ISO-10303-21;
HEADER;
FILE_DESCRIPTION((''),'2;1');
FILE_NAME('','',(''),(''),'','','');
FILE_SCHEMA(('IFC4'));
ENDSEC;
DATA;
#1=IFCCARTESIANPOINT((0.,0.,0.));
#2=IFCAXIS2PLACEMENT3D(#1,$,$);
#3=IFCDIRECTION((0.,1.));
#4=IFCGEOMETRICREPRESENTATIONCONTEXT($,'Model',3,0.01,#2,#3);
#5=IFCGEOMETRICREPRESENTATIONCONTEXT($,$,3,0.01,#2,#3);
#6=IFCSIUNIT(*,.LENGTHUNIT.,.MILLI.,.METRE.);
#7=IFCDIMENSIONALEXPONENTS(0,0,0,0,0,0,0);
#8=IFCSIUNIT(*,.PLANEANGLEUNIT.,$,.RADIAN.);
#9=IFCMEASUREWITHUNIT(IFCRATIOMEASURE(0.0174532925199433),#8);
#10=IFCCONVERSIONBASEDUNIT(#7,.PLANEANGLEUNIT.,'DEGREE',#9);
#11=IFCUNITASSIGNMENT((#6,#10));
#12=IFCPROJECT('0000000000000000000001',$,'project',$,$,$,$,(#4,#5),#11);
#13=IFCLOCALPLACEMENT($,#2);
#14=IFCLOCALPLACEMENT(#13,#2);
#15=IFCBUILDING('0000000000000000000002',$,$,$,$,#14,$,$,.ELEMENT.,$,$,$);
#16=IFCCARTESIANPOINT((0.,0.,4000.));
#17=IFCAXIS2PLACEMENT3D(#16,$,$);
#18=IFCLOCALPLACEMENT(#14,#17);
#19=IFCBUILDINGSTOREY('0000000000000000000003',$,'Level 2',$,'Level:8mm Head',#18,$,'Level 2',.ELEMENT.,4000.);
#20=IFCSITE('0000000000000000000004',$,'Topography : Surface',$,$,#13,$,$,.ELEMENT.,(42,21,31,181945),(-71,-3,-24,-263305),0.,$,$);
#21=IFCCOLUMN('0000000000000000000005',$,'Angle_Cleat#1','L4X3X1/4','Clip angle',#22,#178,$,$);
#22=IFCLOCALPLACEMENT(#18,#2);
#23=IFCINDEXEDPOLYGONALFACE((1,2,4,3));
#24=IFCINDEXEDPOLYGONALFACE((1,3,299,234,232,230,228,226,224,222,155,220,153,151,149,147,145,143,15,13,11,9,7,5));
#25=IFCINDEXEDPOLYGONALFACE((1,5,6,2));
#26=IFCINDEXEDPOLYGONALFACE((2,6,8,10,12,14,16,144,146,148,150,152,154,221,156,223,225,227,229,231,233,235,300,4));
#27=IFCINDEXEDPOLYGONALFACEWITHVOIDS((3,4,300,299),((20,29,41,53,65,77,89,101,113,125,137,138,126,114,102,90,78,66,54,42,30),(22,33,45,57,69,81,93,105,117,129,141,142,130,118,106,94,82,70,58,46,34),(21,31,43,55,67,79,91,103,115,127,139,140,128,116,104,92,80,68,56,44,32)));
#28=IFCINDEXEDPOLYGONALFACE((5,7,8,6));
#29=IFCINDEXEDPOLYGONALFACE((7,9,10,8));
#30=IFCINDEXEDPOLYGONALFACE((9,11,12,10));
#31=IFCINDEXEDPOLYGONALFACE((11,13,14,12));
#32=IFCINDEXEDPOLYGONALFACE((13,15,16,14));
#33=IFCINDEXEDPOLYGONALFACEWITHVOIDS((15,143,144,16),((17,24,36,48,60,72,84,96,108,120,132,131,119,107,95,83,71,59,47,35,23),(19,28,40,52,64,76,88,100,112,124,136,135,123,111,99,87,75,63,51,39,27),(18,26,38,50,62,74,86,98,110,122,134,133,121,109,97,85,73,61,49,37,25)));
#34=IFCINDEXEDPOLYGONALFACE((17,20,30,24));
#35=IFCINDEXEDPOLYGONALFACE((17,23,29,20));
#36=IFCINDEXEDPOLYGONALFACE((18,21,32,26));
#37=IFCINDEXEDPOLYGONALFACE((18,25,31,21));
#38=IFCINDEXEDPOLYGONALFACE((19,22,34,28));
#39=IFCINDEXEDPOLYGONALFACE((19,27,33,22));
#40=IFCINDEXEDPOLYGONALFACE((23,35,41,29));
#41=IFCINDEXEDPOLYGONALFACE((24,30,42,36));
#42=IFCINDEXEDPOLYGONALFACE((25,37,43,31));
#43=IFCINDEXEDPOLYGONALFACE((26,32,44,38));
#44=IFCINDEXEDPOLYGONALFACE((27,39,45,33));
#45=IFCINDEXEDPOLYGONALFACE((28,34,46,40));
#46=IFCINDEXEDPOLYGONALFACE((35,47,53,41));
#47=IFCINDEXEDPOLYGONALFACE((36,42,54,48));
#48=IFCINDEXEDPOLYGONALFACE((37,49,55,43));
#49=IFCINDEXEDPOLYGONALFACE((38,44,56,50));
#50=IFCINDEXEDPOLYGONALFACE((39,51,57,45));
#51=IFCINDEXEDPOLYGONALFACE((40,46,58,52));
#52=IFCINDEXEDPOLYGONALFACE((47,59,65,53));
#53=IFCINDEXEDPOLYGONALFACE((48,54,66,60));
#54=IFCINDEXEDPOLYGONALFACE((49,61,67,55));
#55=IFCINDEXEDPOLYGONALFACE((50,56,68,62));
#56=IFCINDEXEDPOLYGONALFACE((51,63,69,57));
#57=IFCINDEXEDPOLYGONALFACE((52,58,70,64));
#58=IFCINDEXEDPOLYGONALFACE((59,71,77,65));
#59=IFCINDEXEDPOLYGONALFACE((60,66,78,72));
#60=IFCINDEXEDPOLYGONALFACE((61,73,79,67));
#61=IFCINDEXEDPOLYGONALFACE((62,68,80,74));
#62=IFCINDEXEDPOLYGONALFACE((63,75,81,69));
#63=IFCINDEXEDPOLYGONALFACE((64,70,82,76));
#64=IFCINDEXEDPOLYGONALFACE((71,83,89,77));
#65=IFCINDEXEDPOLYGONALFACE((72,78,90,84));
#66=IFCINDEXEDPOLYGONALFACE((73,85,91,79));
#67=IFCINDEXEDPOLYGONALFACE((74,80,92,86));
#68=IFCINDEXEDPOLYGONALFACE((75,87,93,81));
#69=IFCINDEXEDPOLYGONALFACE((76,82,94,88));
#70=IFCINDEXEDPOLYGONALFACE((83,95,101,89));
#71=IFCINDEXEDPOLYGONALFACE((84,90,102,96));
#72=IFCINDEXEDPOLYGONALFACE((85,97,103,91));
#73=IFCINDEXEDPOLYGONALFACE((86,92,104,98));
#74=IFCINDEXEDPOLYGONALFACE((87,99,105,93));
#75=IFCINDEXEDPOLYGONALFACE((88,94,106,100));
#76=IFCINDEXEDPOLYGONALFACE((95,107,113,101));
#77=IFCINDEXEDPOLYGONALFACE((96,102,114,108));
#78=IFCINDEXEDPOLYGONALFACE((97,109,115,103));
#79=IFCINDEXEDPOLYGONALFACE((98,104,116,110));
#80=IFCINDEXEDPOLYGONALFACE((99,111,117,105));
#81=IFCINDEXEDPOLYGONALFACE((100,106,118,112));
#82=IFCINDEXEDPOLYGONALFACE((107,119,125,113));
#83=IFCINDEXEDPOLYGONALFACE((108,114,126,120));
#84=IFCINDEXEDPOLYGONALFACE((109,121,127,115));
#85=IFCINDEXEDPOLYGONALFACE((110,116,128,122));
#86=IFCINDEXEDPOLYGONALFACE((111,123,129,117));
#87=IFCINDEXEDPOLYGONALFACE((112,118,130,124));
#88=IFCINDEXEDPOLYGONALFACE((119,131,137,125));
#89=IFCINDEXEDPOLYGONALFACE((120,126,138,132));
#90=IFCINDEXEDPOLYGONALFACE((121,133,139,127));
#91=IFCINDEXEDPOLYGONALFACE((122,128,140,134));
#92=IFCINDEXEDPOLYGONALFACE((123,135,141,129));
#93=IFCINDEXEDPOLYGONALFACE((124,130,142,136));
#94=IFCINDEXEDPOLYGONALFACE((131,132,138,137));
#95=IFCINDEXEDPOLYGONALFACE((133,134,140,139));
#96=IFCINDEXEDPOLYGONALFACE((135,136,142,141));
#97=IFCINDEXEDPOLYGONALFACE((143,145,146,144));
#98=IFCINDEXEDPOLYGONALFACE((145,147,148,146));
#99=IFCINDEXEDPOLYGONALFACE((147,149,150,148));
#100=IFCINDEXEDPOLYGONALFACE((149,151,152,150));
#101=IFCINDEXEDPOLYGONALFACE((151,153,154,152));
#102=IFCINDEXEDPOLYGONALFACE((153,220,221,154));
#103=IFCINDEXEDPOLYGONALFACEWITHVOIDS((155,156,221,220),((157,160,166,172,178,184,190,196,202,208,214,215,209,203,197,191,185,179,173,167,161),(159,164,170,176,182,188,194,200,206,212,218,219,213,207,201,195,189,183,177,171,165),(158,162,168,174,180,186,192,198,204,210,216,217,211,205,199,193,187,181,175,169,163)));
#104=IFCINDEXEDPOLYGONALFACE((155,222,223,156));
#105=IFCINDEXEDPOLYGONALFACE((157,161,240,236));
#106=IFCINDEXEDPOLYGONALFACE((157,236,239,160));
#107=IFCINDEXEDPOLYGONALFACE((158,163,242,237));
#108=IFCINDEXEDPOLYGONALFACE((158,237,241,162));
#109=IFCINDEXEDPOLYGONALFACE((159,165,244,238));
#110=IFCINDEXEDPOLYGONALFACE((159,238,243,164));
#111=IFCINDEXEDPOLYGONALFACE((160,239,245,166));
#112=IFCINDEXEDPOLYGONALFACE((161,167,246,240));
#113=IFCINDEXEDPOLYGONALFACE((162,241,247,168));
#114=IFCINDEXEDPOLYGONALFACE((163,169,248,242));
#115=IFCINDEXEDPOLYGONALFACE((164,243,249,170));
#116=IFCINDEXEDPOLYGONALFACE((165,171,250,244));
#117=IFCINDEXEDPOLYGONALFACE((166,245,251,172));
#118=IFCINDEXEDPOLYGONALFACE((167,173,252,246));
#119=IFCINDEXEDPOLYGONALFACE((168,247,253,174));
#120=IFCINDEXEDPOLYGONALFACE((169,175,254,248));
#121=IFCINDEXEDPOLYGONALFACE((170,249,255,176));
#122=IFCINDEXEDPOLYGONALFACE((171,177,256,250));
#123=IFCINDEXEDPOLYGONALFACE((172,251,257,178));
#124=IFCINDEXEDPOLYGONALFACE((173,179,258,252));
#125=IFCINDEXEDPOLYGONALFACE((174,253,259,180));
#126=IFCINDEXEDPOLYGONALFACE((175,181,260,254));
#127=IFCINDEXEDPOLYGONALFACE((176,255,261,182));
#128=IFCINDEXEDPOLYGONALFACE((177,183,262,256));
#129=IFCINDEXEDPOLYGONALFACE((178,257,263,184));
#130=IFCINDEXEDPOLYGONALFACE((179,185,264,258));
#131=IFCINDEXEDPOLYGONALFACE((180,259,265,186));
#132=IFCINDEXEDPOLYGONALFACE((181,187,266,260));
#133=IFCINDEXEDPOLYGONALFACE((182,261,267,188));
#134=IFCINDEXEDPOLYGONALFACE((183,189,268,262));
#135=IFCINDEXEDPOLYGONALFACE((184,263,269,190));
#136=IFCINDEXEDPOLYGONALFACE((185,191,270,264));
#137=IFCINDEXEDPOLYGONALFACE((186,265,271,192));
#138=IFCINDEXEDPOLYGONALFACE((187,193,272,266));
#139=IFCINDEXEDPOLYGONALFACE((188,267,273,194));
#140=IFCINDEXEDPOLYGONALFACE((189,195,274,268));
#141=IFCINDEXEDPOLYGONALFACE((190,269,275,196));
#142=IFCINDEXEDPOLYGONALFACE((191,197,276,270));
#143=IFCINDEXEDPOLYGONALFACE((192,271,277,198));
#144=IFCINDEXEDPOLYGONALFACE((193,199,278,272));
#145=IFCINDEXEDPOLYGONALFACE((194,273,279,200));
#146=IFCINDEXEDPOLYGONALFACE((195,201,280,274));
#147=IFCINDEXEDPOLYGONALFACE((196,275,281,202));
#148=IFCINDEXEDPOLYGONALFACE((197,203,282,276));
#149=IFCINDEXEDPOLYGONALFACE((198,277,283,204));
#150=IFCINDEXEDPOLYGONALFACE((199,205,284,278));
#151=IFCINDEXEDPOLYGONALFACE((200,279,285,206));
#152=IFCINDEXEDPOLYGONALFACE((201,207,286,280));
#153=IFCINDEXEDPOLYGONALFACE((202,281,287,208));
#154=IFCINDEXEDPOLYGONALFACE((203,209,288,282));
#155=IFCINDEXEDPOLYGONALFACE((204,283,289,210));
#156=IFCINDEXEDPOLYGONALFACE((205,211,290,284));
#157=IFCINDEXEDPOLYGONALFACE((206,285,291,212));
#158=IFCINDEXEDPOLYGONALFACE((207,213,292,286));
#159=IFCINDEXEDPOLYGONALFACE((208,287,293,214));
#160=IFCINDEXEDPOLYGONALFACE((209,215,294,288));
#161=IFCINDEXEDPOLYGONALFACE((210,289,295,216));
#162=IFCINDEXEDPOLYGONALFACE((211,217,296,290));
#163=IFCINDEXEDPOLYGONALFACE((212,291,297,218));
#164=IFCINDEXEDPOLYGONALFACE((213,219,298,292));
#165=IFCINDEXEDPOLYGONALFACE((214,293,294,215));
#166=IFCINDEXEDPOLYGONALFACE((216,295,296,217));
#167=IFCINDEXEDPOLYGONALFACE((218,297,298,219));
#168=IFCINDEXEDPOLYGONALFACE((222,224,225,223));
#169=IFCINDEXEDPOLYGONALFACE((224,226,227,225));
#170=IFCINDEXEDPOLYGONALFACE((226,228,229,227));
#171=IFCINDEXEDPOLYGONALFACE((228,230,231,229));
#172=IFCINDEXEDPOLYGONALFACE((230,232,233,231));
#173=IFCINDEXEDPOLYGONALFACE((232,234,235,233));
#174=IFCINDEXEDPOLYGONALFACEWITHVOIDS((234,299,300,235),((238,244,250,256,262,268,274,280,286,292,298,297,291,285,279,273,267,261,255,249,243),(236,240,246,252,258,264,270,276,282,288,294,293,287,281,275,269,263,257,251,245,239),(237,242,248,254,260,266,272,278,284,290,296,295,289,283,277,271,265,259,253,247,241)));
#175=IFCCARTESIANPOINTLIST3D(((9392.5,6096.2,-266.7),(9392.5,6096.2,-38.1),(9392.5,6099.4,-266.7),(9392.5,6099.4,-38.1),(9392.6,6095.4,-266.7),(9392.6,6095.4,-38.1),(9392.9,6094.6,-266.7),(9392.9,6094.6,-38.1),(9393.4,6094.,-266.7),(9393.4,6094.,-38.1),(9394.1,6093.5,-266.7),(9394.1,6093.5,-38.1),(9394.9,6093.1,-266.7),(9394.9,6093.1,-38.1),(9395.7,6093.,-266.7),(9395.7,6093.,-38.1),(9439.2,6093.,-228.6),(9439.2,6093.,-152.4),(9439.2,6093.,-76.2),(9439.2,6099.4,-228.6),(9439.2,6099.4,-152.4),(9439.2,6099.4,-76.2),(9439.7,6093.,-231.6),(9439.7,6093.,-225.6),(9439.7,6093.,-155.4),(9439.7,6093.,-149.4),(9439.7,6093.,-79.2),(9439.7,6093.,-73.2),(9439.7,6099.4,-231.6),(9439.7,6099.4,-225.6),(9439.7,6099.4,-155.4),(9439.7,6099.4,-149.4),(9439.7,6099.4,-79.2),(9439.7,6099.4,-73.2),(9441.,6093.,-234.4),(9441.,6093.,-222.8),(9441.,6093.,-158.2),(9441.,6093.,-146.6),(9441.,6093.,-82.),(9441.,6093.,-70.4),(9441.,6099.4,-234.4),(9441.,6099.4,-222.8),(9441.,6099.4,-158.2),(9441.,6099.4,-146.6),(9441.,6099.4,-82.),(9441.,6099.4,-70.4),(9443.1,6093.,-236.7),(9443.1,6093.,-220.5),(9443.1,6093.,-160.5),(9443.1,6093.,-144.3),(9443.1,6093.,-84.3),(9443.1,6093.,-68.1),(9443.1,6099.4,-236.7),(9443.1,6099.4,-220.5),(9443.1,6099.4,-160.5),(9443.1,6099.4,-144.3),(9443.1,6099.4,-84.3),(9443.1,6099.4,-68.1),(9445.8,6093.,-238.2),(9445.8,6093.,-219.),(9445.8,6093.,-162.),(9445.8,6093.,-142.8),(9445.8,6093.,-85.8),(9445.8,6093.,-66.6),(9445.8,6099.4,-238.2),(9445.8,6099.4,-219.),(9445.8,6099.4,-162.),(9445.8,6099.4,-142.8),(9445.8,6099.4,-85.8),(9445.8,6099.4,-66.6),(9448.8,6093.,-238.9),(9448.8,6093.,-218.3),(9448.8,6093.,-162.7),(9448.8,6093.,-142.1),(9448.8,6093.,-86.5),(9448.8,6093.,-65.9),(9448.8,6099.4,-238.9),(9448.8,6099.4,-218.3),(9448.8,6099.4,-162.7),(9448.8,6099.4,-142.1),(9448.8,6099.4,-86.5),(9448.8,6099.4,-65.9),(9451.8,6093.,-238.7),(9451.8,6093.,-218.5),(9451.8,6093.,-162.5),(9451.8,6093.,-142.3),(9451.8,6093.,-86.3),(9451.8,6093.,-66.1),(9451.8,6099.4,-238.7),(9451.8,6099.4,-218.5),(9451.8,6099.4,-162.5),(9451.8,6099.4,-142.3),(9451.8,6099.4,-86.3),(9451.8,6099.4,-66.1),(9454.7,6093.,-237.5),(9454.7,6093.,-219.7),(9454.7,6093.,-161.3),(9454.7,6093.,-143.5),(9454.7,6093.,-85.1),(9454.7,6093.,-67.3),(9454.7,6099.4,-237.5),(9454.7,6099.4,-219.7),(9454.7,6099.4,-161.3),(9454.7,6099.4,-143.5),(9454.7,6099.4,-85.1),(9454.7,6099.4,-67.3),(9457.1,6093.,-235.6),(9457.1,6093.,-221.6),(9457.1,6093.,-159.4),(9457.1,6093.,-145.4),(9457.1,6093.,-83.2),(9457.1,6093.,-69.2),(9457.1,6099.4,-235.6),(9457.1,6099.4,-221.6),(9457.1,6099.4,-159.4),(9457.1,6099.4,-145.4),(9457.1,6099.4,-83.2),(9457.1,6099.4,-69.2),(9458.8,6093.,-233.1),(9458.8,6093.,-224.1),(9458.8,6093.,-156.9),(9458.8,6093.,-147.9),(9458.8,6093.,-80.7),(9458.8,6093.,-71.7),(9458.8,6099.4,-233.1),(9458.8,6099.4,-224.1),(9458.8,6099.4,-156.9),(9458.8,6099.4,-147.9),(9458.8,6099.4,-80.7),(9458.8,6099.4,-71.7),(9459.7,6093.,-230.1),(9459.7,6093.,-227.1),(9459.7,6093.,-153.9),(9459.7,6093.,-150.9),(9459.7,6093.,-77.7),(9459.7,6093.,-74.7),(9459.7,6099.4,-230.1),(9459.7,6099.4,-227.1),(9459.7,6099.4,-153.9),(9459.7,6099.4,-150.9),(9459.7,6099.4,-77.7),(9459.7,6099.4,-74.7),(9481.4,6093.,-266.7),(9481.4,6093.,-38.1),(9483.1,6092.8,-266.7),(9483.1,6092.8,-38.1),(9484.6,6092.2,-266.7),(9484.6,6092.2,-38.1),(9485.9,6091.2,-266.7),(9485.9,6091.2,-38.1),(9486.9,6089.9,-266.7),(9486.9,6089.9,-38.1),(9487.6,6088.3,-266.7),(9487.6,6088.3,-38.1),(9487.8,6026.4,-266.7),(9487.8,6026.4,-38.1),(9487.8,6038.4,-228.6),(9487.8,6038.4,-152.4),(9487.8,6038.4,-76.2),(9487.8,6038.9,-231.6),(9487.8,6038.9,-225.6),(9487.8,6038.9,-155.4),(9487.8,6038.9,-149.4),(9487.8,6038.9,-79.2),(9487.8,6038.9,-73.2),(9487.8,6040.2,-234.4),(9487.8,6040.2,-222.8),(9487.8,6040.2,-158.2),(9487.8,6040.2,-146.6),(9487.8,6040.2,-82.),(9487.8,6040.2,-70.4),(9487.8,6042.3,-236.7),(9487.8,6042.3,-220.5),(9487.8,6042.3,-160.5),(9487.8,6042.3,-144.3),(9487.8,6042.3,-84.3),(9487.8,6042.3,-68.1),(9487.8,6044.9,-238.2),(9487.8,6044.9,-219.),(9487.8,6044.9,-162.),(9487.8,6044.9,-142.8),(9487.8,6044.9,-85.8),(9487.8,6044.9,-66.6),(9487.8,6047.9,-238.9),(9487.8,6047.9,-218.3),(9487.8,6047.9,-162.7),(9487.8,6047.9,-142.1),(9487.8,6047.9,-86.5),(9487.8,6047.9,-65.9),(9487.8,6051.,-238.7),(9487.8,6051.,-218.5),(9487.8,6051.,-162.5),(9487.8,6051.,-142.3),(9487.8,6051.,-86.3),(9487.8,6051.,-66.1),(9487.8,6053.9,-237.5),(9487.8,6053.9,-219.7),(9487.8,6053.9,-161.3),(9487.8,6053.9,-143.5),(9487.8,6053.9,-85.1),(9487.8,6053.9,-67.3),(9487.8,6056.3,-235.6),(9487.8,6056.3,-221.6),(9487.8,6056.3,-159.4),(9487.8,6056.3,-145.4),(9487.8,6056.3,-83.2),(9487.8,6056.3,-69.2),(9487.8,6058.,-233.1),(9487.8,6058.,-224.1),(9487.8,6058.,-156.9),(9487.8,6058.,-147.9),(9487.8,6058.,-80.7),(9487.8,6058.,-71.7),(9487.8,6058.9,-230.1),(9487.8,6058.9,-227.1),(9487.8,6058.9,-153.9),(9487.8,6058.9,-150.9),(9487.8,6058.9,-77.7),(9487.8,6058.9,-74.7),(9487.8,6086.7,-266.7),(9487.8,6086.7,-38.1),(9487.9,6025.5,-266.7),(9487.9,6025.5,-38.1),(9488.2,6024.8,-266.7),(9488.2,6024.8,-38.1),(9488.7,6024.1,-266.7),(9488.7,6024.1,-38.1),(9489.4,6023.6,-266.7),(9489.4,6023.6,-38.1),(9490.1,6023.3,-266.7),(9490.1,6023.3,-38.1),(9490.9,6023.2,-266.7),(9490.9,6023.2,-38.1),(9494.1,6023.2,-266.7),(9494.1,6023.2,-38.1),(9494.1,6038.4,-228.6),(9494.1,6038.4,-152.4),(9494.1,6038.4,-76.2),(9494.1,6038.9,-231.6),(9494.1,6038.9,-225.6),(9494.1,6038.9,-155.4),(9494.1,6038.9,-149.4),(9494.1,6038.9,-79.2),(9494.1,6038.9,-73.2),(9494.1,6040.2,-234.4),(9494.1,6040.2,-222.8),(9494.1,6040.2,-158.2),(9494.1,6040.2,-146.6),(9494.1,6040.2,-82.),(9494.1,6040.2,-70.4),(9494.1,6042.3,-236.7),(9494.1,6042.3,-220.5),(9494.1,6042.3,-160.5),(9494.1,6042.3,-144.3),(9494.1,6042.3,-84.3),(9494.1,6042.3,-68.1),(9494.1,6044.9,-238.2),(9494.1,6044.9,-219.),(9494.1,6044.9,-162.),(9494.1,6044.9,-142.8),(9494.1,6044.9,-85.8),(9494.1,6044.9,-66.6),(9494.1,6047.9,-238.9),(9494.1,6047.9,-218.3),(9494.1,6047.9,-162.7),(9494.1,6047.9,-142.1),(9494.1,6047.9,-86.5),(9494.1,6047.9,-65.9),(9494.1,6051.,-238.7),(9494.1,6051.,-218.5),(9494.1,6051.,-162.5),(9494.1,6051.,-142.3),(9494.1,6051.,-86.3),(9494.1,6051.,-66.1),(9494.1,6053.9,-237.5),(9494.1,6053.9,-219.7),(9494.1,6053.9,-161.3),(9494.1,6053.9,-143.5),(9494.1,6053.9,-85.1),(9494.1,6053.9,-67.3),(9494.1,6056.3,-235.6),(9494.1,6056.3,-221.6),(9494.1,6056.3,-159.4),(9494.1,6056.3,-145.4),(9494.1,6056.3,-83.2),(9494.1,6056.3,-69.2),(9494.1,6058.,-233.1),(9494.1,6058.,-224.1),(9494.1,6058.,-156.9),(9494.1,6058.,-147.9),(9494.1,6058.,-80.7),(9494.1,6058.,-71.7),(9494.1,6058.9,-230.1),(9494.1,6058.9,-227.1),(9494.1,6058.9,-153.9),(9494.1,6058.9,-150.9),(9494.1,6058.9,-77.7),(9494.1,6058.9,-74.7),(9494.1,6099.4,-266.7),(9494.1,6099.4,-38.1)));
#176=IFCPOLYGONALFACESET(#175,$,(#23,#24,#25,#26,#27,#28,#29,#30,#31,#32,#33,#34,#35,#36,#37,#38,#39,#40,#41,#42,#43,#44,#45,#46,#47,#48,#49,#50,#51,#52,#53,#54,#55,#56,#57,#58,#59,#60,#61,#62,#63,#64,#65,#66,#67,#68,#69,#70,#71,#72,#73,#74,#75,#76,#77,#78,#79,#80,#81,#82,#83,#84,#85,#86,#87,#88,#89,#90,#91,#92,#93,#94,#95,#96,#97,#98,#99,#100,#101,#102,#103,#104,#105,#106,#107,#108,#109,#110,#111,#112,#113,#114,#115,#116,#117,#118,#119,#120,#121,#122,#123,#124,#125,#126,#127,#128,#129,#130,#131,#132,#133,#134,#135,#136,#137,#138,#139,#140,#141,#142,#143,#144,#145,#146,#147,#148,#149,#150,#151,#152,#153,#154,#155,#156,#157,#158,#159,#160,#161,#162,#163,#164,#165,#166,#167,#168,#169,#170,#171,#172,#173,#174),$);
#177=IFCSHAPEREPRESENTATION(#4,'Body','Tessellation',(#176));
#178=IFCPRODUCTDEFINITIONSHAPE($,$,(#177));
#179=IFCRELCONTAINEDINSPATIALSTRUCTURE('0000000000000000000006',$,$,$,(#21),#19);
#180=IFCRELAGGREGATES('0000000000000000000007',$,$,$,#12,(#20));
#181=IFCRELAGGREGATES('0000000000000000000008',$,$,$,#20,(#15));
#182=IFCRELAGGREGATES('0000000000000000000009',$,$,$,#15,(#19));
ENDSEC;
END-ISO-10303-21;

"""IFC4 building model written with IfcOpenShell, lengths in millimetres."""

from ifc_helpers import new_model, entity, si_unit, converted_unit, direction, frame, frame_2d, origin, origin_2d_with_axis, place, context, project, spatial, circle, l_section, extrude, element, save


model = new_model("IFC4")

# Units and contexts
model_context = context("Model", 3, precision=0.01, world=origin(), true_north=direction((0.0, 1.0)))
context_of_model = context(None, 3, precision=0.01, world=origin(), true_north=direction((0.0, 1.0)))
ifc_project = project(units=[si_unit("LENGTHUNIT", "METRE", prefix="MILLI"), converted_unit("PLANEANGLEUNIT", "DEGREE", entity("IfcRatioMeasure", 0.0174532925199433), si_unit("PLANEANGLEUNIT", "RADIAN"), dimensions=[0, 0, 0, 0, 0, 0, 0])], contexts=[model_context, context_of_model])

# Site, building, storey
site_placement = place(None, origin())
site = spatial("IfcSite", under=ifc_project, at=site_placement, Name="Topography : Surface", CompositionType="ELEMENT", RefLatitude=(42, 21, 31, 181945), RefLongitude=(-71, -3, -24, -263305), RefElevation=0.0)
building_placement = place(site_placement, origin())
building = spatial("IfcBuilding", under=site, at=building_placement, CompositionType="ELEMENT")
storey_placement = place(building_placement, frame((0.0, 0.0, 4000.0)))
storey = spatial("IfcBuildingStorey", under=building, at=storey_placement, Name="Level 2", ObjectType="Level:8mm Head", LongName="Level 2", CompositionType="ELEMENT", Elevation=4000.0)

# Column, openings
column_1_placement = place(storey_placement, frame((9463.0, 6081.1, -266.7), z_axis=(0.0, 0.0, -1.0), x_axis=(0.0, -1.0, 0.0)))
column_1 = element("IfcColumn", 1, at=column_1_placement, inside=storey, Name="Angle_Cleat#1", Description="L4X3X1/4", ObjectType="Clip angle", context=model_context, shape_type="SweptSolid", body=[
    extrude(l_section(Depth=101.6, Width=76.2, Thickness=6.3, FilletRadius=6.3, EdgeRadius=3.2, at=frame_2d((19.8, 19.7))), origin(), (0.0, 0.0, -1.0), 228.6),
])
opening_1_placement = place(column_1_placement, frame((-18.9, 13.5, -114.3), z_axis=(1.0, 0.0, 0.0), x_axis=(0.0, 1.0, 0.0)))
element("IfcOpeningElement", 2, at=opening_1_placement, cuts=column_1, ObjectType="Opening", context=model_context, shape_type="SweptSolid", body=[
    extrude(circle(Radius=10.3, at=origin_2d_with_axis()), origin(), (0.0, 0.0, 1.0), 7.3),
])
opening_2_placement = place(column_1_placement, frame((-18.9, 13.5, -114.3), z_axis=(1.0, 0.0, 0.0), x_axis=(0.0, 1.0, 0.0)))
element("IfcOpeningElement", 3, at=opening_2_placement, cuts=column_1, ObjectType="Opening", context=model_context, shape_type="SweptSolid", body=[
    extrude(circle(Radius=10.3, at=frame_2d((0.0, 76.2), x_axis=(1.0, 0.0))), origin(), (0.0, 0.0, 1.0), 7.3),
])
opening_3_placement = place(column_1_placement, frame((-18.9, 13.5, -114.3), z_axis=(1.0, 0.0, 0.0), x_axis=(0.0, 1.0, 0.0)))
element("IfcOpeningElement", 4, at=opening_3_placement, cuts=column_1, ObjectType="Opening", context=model_context, shape_type="SweptSolid", body=[
    extrude(circle(Radius=10.3, at=frame_2d((0.0, -76.2), x_axis=(1.0, 0.0))), origin(), (0.0, 0.0, 1.0), 7.3),
])
opening_4_placement = place(column_1_placement, frame((32.4, -31.5, -114.3), z_axis=(0.0, 1.0, 0.0), x_axis=(1.0, 0.0, 0.0)))
element("IfcOpeningElement", 5, at=opening_4_placement, cuts=column_1, ObjectType="Opening", context=model_context, shape_type="SweptSolid", body=[
    extrude(circle(Radius=10.3, at=origin_2d_with_axis()), origin(), (0.0, 0.0, 1.0), 7.3),
])
opening_5_placement = place(column_1_placement, frame((32.4, -31.5, -114.3), z_axis=(0.0, 1.0, 0.0), x_axis=(1.0, 0.0, 0.0)))
element("IfcOpeningElement", 6, at=opening_5_placement, cuts=column_1, ObjectType="Opening", context=model_context, shape_type="SweptSolid", body=[
    extrude(circle(Radius=10.3, at=frame_2d((0.0, 76.2), x_axis=(1.0, 0.0))), origin(), (0.0, 0.0, 1.0), 7.3),
])
opening_6_placement = place(column_1_placement, frame((32.4, -31.5, -114.3), z_axis=(0.0, 1.0, 0.0), x_axis=(1.0, 0.0, 0.0)))
element("IfcOpeningElement", 7, at=opening_6_placement, cuts=column_1, ObjectType="Opening", context=model_context, shape_type="SweptSolid", body=[
    extrude(circle(Radius=10.3, at=frame_2d((0.0, -76.2), x_axis=(1.0, 0.0))), origin(), (0.0, 0.0, 1.0), 7.3),
])

save(model, "model.ifc")
